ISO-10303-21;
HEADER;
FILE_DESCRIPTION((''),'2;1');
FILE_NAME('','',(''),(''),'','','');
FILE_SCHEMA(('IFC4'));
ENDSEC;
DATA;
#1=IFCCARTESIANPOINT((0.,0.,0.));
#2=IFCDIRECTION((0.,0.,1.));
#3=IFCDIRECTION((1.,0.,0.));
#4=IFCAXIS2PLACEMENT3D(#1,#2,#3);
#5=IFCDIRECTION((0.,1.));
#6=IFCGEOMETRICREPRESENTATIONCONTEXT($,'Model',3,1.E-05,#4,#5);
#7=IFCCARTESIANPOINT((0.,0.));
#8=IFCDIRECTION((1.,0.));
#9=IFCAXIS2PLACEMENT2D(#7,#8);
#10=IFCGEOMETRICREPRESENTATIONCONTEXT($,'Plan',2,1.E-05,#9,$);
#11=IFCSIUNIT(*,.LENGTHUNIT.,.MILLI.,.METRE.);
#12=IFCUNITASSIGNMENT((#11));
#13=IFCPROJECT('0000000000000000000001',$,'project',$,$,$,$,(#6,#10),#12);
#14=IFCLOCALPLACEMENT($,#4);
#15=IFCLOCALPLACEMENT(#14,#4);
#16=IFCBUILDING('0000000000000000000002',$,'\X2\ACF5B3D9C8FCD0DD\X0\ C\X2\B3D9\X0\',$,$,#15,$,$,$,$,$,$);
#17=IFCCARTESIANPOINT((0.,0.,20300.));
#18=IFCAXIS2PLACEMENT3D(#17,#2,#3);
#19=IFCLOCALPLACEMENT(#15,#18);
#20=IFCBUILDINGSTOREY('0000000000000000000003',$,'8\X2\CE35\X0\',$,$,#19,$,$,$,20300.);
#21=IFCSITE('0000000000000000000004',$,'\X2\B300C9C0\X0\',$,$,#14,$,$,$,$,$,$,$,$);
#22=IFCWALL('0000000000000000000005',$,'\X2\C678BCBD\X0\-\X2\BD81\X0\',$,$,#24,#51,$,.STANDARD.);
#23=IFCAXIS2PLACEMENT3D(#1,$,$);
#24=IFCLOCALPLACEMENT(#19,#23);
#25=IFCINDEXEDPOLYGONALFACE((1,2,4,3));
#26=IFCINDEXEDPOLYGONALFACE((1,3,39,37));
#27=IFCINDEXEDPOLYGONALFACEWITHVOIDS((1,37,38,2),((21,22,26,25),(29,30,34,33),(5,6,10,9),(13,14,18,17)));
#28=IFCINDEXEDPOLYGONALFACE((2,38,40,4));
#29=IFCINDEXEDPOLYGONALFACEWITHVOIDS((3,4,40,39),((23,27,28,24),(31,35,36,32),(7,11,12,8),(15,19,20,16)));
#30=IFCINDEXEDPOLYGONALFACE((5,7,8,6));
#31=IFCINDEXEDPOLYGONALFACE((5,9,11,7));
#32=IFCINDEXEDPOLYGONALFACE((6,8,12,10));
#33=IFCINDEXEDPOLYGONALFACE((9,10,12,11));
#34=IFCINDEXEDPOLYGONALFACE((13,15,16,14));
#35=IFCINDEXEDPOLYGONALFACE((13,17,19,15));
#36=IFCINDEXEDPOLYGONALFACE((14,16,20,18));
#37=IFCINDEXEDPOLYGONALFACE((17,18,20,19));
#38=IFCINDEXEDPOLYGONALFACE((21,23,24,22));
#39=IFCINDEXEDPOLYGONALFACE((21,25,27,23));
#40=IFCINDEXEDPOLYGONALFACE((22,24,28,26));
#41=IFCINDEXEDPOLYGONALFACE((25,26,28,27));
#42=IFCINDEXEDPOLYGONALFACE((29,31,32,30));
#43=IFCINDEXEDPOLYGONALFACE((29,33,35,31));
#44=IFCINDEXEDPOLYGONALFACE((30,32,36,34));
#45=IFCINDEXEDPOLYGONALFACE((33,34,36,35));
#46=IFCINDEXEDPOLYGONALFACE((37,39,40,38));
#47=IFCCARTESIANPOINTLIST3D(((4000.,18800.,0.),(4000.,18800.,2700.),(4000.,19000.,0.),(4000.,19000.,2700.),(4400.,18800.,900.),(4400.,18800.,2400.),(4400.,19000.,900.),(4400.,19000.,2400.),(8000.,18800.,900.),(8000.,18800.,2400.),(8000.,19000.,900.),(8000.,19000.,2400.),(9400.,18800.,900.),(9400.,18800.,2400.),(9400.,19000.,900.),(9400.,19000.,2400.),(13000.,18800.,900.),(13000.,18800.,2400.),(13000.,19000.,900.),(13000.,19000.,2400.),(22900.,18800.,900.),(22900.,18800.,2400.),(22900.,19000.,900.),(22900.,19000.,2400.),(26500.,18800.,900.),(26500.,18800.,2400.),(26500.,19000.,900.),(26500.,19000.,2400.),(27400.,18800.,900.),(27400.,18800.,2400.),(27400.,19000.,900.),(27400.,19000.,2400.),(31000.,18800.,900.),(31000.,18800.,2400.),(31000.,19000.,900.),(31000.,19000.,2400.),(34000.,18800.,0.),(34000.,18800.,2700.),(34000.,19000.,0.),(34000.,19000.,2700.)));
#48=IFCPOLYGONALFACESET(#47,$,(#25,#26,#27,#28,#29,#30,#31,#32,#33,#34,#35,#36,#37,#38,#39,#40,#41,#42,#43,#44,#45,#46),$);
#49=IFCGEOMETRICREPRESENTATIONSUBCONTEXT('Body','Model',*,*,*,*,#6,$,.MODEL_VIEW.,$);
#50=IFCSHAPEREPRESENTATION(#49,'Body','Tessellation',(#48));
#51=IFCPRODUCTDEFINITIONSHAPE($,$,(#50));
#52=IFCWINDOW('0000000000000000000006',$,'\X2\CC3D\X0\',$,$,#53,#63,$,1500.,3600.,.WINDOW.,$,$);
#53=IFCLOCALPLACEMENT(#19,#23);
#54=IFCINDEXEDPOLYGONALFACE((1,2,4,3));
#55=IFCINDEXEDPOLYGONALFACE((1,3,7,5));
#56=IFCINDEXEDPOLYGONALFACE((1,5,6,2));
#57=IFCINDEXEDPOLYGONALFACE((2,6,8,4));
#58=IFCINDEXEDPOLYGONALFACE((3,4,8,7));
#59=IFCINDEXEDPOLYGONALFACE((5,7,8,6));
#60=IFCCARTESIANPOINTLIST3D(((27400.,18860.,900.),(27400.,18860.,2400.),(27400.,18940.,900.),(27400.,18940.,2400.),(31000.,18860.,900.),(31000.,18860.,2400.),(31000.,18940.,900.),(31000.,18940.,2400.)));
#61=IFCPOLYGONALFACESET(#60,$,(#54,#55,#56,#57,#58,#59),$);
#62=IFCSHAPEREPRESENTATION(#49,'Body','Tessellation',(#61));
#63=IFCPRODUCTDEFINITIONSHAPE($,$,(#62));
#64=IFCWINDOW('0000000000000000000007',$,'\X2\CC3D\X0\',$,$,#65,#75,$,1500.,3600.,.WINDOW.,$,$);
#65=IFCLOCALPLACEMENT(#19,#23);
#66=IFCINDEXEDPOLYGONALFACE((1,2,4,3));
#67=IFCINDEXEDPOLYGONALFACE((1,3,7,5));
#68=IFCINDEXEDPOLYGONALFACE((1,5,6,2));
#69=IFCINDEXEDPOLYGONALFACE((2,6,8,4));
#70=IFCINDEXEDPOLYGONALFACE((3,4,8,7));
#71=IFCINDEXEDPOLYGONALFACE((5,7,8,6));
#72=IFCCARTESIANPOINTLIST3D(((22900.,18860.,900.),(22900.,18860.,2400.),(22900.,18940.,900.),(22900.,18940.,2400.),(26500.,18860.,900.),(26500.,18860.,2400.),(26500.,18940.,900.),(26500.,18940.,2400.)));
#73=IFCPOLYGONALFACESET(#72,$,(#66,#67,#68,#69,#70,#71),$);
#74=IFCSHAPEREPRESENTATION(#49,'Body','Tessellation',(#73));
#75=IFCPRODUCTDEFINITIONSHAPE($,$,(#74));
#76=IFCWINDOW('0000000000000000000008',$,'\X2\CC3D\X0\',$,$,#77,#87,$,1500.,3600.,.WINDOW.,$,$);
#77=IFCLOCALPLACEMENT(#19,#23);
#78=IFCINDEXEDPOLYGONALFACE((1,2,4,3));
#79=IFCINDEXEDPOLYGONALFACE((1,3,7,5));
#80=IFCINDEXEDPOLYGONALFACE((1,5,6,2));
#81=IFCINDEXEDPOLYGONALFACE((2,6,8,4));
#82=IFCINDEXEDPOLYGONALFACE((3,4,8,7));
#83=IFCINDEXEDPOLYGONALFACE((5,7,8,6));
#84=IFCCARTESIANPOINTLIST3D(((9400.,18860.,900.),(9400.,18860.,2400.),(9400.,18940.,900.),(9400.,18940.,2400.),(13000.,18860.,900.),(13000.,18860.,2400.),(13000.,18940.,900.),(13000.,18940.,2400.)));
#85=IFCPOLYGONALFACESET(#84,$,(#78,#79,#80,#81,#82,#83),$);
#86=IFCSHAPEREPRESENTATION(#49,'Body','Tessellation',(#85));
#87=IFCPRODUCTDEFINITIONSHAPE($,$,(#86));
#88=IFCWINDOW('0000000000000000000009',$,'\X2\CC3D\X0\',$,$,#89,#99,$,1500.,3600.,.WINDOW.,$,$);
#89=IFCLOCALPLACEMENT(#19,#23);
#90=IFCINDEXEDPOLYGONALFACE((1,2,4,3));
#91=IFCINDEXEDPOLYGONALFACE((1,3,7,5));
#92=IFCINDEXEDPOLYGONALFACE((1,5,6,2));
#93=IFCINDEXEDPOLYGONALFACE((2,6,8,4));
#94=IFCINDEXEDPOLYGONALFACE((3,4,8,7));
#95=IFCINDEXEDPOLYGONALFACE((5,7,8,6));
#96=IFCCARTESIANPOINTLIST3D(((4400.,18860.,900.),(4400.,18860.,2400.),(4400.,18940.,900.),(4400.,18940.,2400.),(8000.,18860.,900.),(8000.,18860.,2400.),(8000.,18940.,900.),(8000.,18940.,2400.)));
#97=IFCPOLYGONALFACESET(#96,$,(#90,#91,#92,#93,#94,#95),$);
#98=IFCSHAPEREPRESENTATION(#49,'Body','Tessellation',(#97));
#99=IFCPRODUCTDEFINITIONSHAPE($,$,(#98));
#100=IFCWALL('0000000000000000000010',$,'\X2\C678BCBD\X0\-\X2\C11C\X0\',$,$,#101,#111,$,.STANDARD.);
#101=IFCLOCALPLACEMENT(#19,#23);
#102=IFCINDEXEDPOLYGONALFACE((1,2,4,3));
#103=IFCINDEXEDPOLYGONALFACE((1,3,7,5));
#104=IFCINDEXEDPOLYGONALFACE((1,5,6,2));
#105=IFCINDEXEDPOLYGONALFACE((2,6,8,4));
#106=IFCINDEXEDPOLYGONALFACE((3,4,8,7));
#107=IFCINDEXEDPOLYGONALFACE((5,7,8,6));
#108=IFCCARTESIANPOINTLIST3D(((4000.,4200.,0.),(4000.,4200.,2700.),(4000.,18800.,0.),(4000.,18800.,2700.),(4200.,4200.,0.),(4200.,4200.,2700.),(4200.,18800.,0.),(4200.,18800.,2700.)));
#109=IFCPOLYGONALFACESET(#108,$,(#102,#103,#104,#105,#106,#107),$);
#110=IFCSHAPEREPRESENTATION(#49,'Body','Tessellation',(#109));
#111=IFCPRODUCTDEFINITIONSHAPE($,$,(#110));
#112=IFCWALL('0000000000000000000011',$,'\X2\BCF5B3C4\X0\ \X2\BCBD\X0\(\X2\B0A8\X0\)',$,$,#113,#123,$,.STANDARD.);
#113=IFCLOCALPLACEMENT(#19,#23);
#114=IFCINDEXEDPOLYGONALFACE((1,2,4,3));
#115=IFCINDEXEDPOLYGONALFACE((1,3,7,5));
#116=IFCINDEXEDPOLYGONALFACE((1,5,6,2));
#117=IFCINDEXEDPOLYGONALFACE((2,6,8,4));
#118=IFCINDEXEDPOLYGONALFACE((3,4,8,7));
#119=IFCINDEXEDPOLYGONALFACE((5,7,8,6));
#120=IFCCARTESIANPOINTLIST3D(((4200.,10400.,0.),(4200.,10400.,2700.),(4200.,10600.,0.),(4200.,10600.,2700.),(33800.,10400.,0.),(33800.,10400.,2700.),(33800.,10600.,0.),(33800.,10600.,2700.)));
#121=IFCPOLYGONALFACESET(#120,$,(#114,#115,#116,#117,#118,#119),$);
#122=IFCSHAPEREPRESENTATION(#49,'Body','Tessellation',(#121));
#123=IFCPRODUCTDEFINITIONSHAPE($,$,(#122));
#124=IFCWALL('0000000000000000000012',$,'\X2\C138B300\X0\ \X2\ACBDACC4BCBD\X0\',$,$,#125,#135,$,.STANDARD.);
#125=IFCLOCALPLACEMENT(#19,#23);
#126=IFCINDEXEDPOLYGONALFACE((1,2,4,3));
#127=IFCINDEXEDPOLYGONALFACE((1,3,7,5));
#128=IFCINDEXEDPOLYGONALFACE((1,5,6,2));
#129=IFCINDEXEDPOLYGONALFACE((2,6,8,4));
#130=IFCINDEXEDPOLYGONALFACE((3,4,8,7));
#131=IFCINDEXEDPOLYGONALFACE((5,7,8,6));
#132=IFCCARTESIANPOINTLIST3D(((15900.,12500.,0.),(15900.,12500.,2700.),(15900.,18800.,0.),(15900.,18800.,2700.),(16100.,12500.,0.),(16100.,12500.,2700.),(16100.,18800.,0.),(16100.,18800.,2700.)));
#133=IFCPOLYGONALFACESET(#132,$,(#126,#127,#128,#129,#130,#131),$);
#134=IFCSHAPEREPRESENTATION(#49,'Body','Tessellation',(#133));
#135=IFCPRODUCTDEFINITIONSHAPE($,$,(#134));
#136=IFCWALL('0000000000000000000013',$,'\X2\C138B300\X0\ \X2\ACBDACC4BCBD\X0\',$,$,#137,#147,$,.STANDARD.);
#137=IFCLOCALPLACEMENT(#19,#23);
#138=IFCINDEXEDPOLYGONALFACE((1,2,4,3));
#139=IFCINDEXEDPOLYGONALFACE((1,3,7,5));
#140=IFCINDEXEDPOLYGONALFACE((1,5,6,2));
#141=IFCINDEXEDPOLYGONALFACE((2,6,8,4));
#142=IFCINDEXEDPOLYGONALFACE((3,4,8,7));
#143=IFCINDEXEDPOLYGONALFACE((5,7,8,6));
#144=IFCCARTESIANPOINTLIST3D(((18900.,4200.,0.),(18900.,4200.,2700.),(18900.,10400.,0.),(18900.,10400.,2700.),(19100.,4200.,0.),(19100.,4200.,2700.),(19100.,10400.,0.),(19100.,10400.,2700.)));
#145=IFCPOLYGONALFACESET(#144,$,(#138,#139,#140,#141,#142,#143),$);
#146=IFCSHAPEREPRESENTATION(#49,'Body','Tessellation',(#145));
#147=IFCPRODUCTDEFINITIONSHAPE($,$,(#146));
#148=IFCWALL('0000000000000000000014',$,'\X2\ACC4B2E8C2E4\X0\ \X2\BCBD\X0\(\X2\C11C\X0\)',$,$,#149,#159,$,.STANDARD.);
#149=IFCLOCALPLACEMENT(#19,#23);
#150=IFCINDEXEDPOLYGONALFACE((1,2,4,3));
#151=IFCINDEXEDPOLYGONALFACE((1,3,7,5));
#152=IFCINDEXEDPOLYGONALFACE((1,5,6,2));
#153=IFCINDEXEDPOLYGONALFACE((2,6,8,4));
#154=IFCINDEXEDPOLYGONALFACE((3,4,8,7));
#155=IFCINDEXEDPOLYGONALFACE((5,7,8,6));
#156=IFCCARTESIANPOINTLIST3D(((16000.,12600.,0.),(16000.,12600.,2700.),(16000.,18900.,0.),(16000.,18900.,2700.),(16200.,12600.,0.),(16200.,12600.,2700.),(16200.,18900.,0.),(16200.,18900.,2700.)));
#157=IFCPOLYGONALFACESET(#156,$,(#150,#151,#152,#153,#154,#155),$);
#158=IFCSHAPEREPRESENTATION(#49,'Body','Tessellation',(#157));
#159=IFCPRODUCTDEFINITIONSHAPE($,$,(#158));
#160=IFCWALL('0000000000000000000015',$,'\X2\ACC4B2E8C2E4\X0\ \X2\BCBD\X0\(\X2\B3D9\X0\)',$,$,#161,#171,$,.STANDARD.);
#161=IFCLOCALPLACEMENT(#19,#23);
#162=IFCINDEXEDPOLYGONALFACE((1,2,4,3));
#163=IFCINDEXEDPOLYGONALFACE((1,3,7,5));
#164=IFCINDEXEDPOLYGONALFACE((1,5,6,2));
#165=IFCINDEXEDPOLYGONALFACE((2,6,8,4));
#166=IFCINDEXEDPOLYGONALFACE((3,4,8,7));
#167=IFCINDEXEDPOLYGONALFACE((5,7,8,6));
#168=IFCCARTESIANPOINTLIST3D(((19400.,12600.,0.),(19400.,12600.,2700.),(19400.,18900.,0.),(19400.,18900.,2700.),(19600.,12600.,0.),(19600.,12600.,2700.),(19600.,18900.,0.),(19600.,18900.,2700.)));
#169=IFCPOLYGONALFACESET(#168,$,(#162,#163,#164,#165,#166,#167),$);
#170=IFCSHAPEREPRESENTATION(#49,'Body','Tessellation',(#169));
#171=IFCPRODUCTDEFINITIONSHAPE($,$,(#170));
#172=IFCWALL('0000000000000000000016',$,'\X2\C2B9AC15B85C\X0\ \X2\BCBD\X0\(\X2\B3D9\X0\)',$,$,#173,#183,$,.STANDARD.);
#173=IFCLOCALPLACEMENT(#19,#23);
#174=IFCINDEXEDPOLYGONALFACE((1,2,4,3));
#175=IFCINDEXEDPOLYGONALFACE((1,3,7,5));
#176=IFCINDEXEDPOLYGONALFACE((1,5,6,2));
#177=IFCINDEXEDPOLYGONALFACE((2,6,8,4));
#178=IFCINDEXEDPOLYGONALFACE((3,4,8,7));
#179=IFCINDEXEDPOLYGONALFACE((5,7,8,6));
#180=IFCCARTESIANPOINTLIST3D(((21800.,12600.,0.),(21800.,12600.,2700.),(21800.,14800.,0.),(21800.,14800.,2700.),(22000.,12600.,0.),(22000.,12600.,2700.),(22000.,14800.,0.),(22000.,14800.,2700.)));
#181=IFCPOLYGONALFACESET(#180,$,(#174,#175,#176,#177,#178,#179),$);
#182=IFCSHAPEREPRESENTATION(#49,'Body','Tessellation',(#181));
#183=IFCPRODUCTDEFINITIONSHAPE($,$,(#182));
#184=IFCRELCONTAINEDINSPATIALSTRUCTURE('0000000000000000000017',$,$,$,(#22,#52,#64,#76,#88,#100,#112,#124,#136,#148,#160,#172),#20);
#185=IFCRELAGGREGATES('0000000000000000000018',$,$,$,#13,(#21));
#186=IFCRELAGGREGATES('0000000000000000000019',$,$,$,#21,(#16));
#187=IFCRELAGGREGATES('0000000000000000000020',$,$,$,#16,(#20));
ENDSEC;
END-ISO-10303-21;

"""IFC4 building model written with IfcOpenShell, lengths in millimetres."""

from ifc_helpers import new_model, si_unit, direction, frame, origin_with_axes, origin_2d_with_axis, place, context, subcontext, project, spatial, polyline, outline, extrude, element, fill, save


model = new_model("IFC4")

# Units and contexts
model_context = context("Model", 3, precision=1e-05, world=origin_with_axes(), true_north=direction((0.0, 1.0)))
plan_context = context("Plan", 2, precision=1e-05, world=origin_2d_with_axis())
body_context = subcontext(model_context, "Body", "Model", "MODEL_VIEW")
ifc_project = project(units=[si_unit("LENGTHUNIT", "METRE", prefix="MILLI")], contexts=[model_context, plan_context])

# Site, building, storey
site_placement = place(None, origin_with_axes())
site = spatial("IfcSite", under=ifc_project, at=site_placement, Name="대지")
building_placement = place(site_placement, origin_with_axes())
building = spatial("IfcBuilding", under=site, at=building_placement, Name="공동주택 C동")
storey_placement = place(building_placement, frame((0.0, 0.0, 20300.0), z_axis=(0.0, 0.0, 1.0), x_axis=(1.0, 0.0, 0.0)))
storey = spatial("IfcBuildingStorey", under=building, at=storey_placement, Name="8층", Elevation=20300.0)

# Wall, openings, windows
wall_1_placement = place(storey_placement, origin_with_axes())
wall_1 = element("IfcWall", 1, at=wall_1_placement, inside=storey, Name="외벽-북", PredefinedType="STANDARD", context=body_context, shape_type="SweptSolid", body=[
    extrude(outline(polyline([(34000.0, 18800.0), (4000.0, 18800.0), (4000.0, 19000.0), (34000.0, 19000.0), (34000.0, 18800.0)])), origin_with_axes(), (0.0, 0.0, 1.0), 2700.0),
])
opening_1_placement = place(storey_placement, origin_with_axes())
opening_1 = element("IfcOpeningElement", 2, at=opening_1_placement, cuts=wall_1, PredefinedType="OPENING", context=body_context, shape_type="SweptSolid", body=[
    extrude(outline(polyline([(31000.0, 19050.0), (27400.0, 19050.0), (27400.0, 18750.0), (31000.0, 18750.0), (31000.0, 19050.0)])), frame((0.0, 0.0, 900.0), z_axis=(0.0, 0.0, 1.0), x_axis=(1.0, 0.0, 0.0)), (0.0, 0.0, 1.0), 1500.0),
])
opening_2_placement = place(storey_placement, origin_with_axes())
opening_2 = element("IfcOpeningElement", 3, at=opening_2_placement, cuts=wall_1, PredefinedType="OPENING", context=body_context, shape_type="SweptSolid", body=[
    extrude(outline(polyline([(26500.0, 19050.0), (22900.0, 19050.0), (22900.0, 18750.0), (26500.0, 18750.0), (26500.0, 19050.0)])), frame((0.0, 0.0, 900.0), z_axis=(0.0, 0.0, 1.0), x_axis=(1.0, 0.0, 0.0)), (0.0, 0.0, 1.0), 1500.0),
])
opening_3_placement = place(storey_placement, origin_with_axes())
opening_3 = element("IfcOpeningElement", 4, at=opening_3_placement, cuts=wall_1, PredefinedType="OPENING", context=body_context, shape_type="SweptSolid", body=[
    extrude(outline(polyline([(13000.0, 19050.0), (9400.0, 19050.0), (9400.0, 18750.0), (13000.0, 18750.0), (13000.0, 19050.0)])), frame((0.0, 0.0, 900.0), z_axis=(0.0, 0.0, 1.0), x_axis=(1.0, 0.0, 0.0)), (0.0, 0.0, 1.0), 1500.0),
])
opening_4_placement = place(storey_placement, origin_with_axes())
opening_4 = element("IfcOpeningElement", 5, at=opening_4_placement, cuts=wall_1, PredefinedType="OPENING", context=body_context, shape_type="SweptSolid", body=[
    extrude(outline(polyline([(8000.0, 19050.0), (4400.0, 19050.0), (4400.0, 18750.0), (8000.0, 18750.0), (8000.0, 19050.0)])), frame((0.0, 0.0, 900.0), z_axis=(0.0, 0.0, 1.0), x_axis=(1.0, 0.0, 0.0)), (0.0, 0.0, 1.0), 1500.0),
])
window_1_placement = place(storey_placement, origin_with_axes())
window_1 = element("IfcWindow", 6, at=window_1_placement, inside=storey, Name="창", OverallHeight=1500.0, OverallWidth=3600.0, PredefinedType="WINDOW", context=body_context, shape_type="SweptSolid", body=[
    extrude(outline(polyline([(31000.0, 18940.0), (27400.0, 18940.0), (27400.0, 18860.0), (31000.0, 18860.0), (31000.0, 18940.0)])), frame((0.0, 0.0, 900.0), z_axis=(0.0, 0.0, 1.0), x_axis=(1.0, 0.0, 0.0)), (0.0, 0.0, 1.0), 1500.0),
])
fill(opening_1, window_1)
window_2_placement = place(storey_placement, origin_with_axes())
window_2 = element("IfcWindow", 7, at=window_2_placement, inside=storey, Name="창", OverallHeight=1500.0, OverallWidth=3600.0, PredefinedType="WINDOW", context=body_context, shape_type="SweptSolid", body=[
    extrude(outline(polyline([(26500.0, 18940.0), (22900.0, 18940.0), (22900.0, 18860.0), (26500.0, 18860.0), (26500.0, 18940.0)])), frame((0.0, 0.0, 900.0), z_axis=(0.0, 0.0, 1.0), x_axis=(1.0, 0.0, 0.0)), (0.0, 0.0, 1.0), 1500.0),
])
fill(opening_2, window_2)
window_3_placement = place(storey_placement, origin_with_axes())
window_3 = element("IfcWindow", 8, at=window_3_placement, inside=storey, Name="창", OverallHeight=1500.0, OverallWidth=3600.0, PredefinedType="WINDOW", context=body_context, shape_type="SweptSolid", body=[
    extrude(outline(polyline([(13000.0, 18940.0), (9400.0, 18940.0), (9400.0, 18860.0), (13000.0, 18860.0), (13000.0, 18940.0)])), frame((0.0, 0.0, 900.0), z_axis=(0.0, 0.0, 1.0), x_axis=(1.0, 0.0, 0.0)), (0.0, 0.0, 1.0), 1500.0),
])
fill(opening_3, window_3)
window_4_placement = place(storey_placement, origin_with_axes())
window_4 = element("IfcWindow", 9, at=window_4_placement, inside=storey, Name="창", OverallHeight=1500.0, OverallWidth=3600.0, PredefinedType="WINDOW", context=body_context, shape_type="SweptSolid", body=[
    extrude(outline(polyline([(8000.0, 18940.0), (4400.0, 18940.0), (4400.0, 18860.0), (8000.0, 18860.0), (8000.0, 18940.0)])), frame((0.0, 0.0, 900.0), z_axis=(0.0, 0.0, 1.0), x_axis=(1.0, 0.0, 0.0)), (0.0, 0.0, 1.0), 1500.0),
])
fill(opening_4, window_4)

# Walls
wall_2_placement = place(storey_placement, origin_with_axes())
element("IfcWall", 10, at=wall_2_placement, inside=storey, Name="외벽-서", PredefinedType="STANDARD", context=body_context, shape_type="SweptSolid", body=[
    extrude(outline(polyline([(4200.0, 18800.0), (4200.0, 4200.0), (4000.0, 4200.0), (4000.0, 18800.0), (4200.0, 18800.0)])), origin_with_axes(), (0.0, 0.0, 1.0), 2700.0),
])
wall_3_placement = place(storey_placement, origin_with_axes())
element("IfcWall", 11, at=wall_3_placement, inside=storey, Name="복도 벽(남)", PredefinedType="STANDARD", context=body_context, shape_type="SweptSolid", body=[
    extrude(outline(polyline([(4200.0, 10600.0), (33800.0, 10600.0), (33800.0, 10400.0), (4200.0, 10400.0), (4200.0, 10600.0)])), origin_with_axes(), (0.0, 0.0, 1.0), 2700.0),
])
wall_4_placement = place(storey_placement, origin_with_axes())
element("IfcWall", 12, at=wall_4_placement, inside=storey, Name="세대 경계벽", PredefinedType="STANDARD", context=body_context, shape_type="SweptSolid", body=[
    extrude(outline(polyline([(15900.0, 12500.0), (15900.0, 18800.0), (16100.0, 18800.0), (16100.0, 12500.0), (15900.0, 12500.0)])), origin_with_axes(), (0.0, 0.0, 1.0), 2700.0),
])
wall_5_placement = place(storey_placement, origin_with_axes())
element("IfcWall", 13, at=wall_5_placement, inside=storey, Name="세대 경계벽", PredefinedType="STANDARD", context=body_context, shape_type="SweptSolid", body=[
    extrude(outline(polyline([(18900.0, 4200.0), (18900.0, 10400.0), (19100.0, 10400.0), (19100.0, 4200.0), (18900.0, 4200.0)])), origin_with_axes(), (0.0, 0.0, 1.0), 2700.0),
])
wall_6_placement = place(storey_placement, origin_with_axes())
element("IfcWall", 14, at=wall_6_placement, inside=storey, Name="계단실 벽(서)", PredefinedType="STANDARD", context=body_context, shape_type="SweptSolid", body=[
    extrude(outline(polyline([(16000.0, 12600.0), (16000.0, 18900.0), (16200.0, 18900.0), (16200.0, 12600.0), (16000.0, 12600.0)])), origin_with_axes(), (0.0, 0.0, 1.0), 2700.0),
])
wall_7_placement = place(storey_placement, origin_with_axes())
element("IfcWall", 15, at=wall_7_placement, inside=storey, Name="계단실 벽(동)", PredefinedType="STANDARD", context=body_context, shape_type="SweptSolid", body=[
    extrude(outline(polyline([(19400.0, 12600.0), (19400.0, 18900.0), (19600.0, 18900.0), (19600.0, 12600.0), (19400.0, 12600.0)])), origin_with_axes(), (0.0, 0.0, 1.0), 2700.0),
])
wall_8_placement = place(storey_placement, origin_with_axes())
element("IfcWall", 16, at=wall_8_placement, inside=storey, Name="승강로 벽(동)", PredefinedType="STANDARD", context=body_context, shape_type="SweptSolid", body=[
    extrude(outline(polyline([(21800.0, 12600.0), (21800.0, 14800.0), (22000.0, 14800.0), (22000.0, 12600.0), (21800.0, 12600.0)])), origin_with_axes(), (0.0, 0.0, 1.0), 2700.0),
])

save(model, "model.ifc")
